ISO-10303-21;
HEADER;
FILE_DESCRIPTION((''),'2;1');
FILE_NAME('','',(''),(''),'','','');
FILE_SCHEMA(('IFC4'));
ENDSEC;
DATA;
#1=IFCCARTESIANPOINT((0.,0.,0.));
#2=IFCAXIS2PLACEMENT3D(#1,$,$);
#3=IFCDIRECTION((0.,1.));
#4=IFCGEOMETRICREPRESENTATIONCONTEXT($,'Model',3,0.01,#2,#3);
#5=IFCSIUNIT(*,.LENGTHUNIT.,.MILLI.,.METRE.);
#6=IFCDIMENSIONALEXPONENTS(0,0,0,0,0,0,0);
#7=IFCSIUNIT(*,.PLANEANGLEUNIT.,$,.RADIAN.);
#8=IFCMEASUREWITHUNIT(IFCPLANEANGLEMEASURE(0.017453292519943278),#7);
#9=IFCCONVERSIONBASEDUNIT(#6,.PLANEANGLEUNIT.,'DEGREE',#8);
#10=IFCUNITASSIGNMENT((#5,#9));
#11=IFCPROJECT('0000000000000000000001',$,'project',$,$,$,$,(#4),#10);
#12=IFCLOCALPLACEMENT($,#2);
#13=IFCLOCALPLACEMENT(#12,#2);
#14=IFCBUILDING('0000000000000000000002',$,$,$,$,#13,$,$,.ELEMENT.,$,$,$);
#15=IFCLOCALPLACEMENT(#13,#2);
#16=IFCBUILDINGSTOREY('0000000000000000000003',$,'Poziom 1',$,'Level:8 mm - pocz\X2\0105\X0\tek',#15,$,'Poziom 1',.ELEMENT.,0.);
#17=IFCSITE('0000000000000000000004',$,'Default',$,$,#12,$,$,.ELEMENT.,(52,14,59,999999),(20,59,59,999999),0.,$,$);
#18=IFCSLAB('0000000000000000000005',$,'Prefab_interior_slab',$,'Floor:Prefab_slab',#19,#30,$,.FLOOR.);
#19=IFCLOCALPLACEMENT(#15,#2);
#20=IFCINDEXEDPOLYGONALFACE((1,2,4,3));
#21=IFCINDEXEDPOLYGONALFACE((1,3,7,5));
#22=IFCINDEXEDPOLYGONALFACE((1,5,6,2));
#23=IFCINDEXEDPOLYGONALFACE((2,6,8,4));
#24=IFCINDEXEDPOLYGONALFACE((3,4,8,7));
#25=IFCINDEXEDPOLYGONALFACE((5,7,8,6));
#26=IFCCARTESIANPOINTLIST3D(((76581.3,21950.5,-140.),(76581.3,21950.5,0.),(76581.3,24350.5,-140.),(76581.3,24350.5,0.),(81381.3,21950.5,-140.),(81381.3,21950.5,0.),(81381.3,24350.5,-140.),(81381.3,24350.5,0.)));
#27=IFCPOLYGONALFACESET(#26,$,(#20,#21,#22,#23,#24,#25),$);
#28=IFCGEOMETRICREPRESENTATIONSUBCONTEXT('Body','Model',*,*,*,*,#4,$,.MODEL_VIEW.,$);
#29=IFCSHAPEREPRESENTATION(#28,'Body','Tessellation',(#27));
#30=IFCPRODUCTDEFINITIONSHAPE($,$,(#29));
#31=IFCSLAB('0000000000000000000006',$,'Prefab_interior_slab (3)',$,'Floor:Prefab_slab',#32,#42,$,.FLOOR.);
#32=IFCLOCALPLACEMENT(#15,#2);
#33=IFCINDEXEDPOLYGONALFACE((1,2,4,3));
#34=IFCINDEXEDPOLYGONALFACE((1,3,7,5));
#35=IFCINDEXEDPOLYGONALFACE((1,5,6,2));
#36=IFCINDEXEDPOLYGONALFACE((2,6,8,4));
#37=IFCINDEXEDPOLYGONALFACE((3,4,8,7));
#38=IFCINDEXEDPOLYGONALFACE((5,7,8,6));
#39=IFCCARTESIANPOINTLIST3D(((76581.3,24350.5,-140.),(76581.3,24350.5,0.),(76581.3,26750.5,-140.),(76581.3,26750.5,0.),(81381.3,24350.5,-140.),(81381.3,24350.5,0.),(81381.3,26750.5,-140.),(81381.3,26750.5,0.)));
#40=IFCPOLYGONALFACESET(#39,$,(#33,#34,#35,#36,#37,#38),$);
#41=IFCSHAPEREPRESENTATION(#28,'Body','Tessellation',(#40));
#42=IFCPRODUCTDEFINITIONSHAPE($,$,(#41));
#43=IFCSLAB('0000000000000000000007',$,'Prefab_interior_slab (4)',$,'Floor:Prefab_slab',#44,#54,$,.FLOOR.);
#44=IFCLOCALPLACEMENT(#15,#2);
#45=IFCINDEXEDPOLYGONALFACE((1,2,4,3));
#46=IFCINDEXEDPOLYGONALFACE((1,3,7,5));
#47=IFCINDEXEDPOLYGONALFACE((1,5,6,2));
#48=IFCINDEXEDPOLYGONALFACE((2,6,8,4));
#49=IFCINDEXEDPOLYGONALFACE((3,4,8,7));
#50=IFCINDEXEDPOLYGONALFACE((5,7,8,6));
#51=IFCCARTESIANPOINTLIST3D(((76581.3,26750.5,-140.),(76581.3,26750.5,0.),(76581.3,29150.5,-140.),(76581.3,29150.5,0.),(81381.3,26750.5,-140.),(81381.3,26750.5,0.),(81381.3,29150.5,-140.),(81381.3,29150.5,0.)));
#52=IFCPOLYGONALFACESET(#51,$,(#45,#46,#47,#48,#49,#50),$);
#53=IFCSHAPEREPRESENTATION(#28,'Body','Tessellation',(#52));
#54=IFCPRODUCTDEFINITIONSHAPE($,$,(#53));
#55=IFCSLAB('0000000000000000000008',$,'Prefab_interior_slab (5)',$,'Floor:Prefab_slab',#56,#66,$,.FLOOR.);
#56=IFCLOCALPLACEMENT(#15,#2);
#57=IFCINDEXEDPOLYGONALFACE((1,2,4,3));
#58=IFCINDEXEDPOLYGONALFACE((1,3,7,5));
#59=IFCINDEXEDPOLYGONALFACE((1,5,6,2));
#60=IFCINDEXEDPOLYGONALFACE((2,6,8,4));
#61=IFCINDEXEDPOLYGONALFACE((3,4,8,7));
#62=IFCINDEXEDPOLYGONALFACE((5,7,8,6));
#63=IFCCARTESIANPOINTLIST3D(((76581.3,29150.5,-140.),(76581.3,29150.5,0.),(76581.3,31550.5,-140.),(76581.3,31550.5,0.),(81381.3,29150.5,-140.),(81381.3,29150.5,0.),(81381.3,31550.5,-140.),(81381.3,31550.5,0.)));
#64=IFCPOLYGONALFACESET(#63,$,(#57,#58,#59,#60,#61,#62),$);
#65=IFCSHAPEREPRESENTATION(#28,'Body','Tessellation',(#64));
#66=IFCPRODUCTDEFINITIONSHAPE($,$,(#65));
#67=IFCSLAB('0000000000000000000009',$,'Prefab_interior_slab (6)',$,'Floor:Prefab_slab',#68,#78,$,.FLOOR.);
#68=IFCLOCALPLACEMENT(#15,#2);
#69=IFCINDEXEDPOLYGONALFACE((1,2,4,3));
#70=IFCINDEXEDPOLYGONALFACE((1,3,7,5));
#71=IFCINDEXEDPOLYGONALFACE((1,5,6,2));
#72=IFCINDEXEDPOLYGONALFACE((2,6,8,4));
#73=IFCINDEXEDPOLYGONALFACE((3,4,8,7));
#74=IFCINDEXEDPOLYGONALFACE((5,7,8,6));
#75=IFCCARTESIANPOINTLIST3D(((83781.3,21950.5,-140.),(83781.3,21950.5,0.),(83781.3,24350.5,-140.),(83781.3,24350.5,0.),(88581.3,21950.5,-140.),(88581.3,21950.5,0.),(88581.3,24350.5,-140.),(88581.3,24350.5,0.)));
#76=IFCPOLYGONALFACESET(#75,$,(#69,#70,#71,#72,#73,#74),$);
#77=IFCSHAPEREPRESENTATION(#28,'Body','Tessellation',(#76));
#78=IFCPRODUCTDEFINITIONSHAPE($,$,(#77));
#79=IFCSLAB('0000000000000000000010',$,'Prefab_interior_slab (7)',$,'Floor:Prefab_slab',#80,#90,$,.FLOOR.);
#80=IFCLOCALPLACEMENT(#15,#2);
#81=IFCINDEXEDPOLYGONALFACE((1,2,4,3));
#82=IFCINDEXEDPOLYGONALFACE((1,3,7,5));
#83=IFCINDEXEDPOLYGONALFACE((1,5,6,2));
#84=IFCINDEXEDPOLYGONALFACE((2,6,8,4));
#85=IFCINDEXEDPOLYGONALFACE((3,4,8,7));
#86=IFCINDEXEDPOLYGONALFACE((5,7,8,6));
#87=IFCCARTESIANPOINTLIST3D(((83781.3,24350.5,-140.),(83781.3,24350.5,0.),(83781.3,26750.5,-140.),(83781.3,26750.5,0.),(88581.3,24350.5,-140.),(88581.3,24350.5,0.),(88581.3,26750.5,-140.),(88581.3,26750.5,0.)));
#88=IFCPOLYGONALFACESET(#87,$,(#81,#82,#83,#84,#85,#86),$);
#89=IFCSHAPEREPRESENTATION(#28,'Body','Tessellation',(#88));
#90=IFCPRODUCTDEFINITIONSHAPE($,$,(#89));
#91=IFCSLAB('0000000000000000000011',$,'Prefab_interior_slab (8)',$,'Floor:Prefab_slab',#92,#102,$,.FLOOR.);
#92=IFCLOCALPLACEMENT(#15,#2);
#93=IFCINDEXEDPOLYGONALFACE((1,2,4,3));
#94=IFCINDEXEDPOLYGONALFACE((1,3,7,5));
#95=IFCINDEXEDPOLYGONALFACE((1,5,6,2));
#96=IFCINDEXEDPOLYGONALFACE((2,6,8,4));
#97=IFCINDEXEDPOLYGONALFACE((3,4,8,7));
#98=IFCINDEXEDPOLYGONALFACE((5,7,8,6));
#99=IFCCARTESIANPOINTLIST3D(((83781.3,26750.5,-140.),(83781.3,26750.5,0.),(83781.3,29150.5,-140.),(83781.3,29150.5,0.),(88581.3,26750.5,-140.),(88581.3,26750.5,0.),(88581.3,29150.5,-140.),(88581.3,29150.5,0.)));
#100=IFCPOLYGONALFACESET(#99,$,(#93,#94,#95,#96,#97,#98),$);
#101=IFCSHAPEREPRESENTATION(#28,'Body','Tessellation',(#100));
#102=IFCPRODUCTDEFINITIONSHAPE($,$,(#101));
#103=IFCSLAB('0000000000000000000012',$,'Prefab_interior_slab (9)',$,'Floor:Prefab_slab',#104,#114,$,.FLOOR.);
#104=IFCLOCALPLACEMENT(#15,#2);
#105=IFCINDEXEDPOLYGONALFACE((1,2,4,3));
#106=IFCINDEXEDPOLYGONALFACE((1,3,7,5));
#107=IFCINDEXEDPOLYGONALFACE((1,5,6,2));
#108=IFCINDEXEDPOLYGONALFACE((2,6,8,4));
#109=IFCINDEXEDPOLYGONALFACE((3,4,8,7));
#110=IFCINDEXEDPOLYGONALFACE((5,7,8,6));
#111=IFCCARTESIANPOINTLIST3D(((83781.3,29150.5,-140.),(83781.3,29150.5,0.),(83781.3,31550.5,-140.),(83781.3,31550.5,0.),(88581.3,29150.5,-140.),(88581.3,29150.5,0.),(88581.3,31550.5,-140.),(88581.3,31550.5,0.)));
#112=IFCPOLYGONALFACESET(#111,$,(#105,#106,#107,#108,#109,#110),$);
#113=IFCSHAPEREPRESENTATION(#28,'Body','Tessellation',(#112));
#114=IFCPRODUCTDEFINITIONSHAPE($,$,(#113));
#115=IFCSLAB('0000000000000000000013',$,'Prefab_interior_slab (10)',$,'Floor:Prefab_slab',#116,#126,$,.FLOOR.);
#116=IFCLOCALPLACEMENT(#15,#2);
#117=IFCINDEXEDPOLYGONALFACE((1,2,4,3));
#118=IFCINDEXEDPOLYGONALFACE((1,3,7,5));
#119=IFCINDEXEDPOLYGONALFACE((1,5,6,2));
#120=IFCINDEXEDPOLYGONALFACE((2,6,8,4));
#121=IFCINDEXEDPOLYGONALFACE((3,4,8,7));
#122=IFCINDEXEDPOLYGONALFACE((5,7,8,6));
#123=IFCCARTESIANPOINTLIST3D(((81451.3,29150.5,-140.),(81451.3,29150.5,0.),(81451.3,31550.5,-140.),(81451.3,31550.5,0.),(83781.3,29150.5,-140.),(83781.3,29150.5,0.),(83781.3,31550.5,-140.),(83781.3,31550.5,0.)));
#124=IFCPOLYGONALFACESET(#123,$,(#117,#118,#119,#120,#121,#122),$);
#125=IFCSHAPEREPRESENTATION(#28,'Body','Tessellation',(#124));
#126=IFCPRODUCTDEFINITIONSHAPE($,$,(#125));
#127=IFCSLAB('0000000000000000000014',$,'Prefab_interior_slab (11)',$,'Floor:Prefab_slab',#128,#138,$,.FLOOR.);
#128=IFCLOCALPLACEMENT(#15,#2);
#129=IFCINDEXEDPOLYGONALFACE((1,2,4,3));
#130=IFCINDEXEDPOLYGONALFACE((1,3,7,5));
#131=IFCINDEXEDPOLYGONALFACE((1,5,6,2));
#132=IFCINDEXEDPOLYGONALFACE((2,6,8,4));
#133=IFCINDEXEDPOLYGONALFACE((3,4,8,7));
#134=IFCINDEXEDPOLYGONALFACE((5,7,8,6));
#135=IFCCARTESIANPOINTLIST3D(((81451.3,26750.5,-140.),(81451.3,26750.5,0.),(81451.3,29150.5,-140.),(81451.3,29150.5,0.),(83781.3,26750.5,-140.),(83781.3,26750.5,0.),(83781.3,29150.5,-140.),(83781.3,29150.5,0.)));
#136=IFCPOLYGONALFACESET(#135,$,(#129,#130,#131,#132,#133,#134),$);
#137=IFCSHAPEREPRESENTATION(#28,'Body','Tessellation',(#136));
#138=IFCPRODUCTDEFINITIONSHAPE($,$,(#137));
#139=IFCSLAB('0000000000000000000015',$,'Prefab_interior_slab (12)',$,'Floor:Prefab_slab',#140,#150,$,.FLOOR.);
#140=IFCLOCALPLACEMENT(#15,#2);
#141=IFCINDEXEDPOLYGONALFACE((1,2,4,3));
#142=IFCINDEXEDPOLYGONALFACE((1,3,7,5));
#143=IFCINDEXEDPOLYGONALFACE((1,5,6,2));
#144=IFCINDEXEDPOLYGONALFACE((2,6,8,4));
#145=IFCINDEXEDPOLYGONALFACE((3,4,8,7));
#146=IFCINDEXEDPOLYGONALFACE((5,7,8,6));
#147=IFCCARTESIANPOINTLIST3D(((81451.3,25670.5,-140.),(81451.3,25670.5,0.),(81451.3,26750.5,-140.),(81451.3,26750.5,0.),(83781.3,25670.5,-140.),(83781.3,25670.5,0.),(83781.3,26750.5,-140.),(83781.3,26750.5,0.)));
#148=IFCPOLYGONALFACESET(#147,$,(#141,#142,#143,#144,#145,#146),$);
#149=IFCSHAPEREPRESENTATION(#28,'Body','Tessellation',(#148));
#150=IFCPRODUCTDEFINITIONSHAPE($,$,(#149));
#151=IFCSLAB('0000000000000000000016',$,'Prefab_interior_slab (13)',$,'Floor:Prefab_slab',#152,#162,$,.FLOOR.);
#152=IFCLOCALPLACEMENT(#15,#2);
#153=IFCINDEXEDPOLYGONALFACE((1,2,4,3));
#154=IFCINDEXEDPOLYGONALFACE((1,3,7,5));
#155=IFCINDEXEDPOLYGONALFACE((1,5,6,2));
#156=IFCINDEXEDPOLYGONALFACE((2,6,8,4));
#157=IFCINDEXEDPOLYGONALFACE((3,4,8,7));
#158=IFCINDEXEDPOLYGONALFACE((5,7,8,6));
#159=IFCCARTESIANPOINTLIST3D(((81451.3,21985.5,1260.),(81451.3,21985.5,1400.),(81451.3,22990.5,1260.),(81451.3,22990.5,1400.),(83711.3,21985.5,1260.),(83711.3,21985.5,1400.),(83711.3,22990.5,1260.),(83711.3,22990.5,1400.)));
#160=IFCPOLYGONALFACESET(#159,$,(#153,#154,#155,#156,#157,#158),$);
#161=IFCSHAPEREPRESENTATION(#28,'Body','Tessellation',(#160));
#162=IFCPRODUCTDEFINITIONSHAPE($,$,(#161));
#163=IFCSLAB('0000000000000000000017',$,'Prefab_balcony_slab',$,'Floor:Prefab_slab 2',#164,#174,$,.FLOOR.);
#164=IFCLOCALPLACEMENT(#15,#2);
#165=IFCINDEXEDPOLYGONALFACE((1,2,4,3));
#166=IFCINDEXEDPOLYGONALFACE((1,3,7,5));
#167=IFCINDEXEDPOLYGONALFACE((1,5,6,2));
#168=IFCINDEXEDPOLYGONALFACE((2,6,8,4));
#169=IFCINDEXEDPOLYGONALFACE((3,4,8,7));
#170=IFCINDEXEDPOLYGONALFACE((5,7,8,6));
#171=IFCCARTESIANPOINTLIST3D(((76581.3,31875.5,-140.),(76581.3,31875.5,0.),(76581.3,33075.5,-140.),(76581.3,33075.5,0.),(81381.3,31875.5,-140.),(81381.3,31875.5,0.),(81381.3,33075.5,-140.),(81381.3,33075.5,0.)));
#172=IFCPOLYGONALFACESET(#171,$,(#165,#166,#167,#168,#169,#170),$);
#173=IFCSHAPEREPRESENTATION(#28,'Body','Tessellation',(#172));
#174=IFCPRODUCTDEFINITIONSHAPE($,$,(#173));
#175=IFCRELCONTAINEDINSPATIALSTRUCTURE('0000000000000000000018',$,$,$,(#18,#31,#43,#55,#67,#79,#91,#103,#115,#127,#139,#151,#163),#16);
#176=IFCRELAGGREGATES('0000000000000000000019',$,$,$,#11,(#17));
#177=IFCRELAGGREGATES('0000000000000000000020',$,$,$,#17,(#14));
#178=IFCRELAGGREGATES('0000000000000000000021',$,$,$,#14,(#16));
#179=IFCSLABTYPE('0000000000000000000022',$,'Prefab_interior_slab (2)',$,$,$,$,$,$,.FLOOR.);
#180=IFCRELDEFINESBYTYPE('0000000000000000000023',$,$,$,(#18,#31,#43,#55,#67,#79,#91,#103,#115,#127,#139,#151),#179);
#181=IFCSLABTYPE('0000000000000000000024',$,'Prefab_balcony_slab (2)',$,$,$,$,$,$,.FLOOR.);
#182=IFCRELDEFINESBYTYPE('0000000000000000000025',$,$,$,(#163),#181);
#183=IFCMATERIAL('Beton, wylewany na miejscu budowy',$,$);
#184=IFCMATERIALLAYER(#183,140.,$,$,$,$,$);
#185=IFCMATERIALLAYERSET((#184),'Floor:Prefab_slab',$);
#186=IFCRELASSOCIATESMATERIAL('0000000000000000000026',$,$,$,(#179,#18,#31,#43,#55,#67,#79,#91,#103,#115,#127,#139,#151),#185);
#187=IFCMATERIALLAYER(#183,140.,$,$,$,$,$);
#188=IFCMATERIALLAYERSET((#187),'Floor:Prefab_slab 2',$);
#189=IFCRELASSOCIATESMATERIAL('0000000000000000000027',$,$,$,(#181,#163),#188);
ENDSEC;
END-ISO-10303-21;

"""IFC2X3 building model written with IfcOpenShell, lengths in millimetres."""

from ifc_helpers import new_model, entity, si_unit, converted_unit, direction, frame, frame_2d, origin, origin_2d_with_axis, place, context, subcontext, project, spatial, rectangle, extrude, material, layer, layer_set, layer_usage, type_object, element, save


model = new_model("IFC2X3")

# Units and contexts
model_context = context("Model", 3, precision=0.01, world=origin(), true_north=direction((0.0, 1.0)))
body_context = subcontext(model_context, "Body", "Model", "MODEL_VIEW")
ifc_project = project(units=[si_unit("LENGTHUNIT", "METRE", prefix="MILLI"), converted_unit("PLANEANGLEUNIT", "DEGREE", entity("IfcPlaneAngleMeasure", 0.017453292519943278), si_unit("PLANEANGLEUNIT", "RADIAN"), dimensions=[0, 0, 0, 0, 0, 0, 0])], contexts=[model_context])

# Site, building, storey
site_placement = place(None, origin())
site = spatial("IfcSite", under=ifc_project, at=site_placement, Name="Default", CompositionType="ELEMENT", RefLatitude=(52, 14, 59, 999999), RefLongitude=(20, 59, 59, 999999), RefElevation=0.0)
building_placement = place(site_placement, origin())
building = spatial("IfcBuilding", under=site, at=building_placement, CompositionType="ELEMENT")
storey_placement = place(building_placement, origin())
storey = spatial("IfcBuildingStorey", under=building, at=storey_placement, Name="Poziom 1", ObjectType="Level:8 mm - początek", LongName="Poziom 1", CompositionType="ELEMENT", Elevation=0.0)

# Slabs
ifc_material_1 = material(Name="Beton, wylewany na miejscu budowy")
ifc_layer_1 = layer(ifc_material_1, 140.0)
ifc_layer_set_1 = layer_set([ifc_layer_1], Name="Floor:Prefab_slab")
ifc_layer_usage_1 = layer_usage(ifc_layer_set_1, "AXIS3", "POSITIVE", 0.0)
slab_type_1 = type_object("IfcSlabType", Name="Prefab_interior_slab (2)", PredefinedType="FLOOR", material=ifc_layer_set_1)
slab_1_placement = place(storey_placement, origin())
element("IfcSlab", 1, at=slab_1_placement, inside=storey, type_object=slab_type_1, material=ifc_layer_usage_1, Name="Prefab_interior_slab", ObjectType="Floor:Prefab_slab", PredefinedType="FLOOR", context=body_context, shape_type="SweptSolid", body=[
    extrude(rectangle(XDim=2400.0, YDim=4800.0, at=frame_2d((0.0, 0.0), x_axis=(1.0, 0.0))), frame((78981.3, 23150.5, 0.0), z_axis=(0.0, 0.0, -1.0), x_axis=(0.0, 1.0, 0.0)), (0.0, 0.0, 1.0), 140.0),
])
ifc_layer_usage_2 = layer_usage(ifc_layer_set_1, "AXIS3", "POSITIVE", 0.0)
slab_2_placement = place(storey_placement, origin())
element("IfcSlab", 2, at=slab_2_placement, inside=storey, type_object=slab_type_1, material=ifc_layer_usage_2, Name="Prefab_interior_slab (3)", ObjectType="Floor:Prefab_slab", PredefinedType="FLOOR", context=body_context, shape_type="SweptSolid", body=[
    extrude(rectangle(XDim=2400.0, YDim=4800.0, at=frame_2d((0.0, 0.0), x_axis=(1.0, 0.0))), frame((78981.3, 25550.5, 0.0), z_axis=(0.0, 0.0, -1.0), x_axis=(0.0, 1.0, 0.0)), (0.0, 0.0, 1.0), 140.0),
])
ifc_layer_usage_3 = layer_usage(ifc_layer_set_1, "AXIS3", "POSITIVE", 0.0)
slab_3_placement = place(storey_placement, origin())
element("IfcSlab", 3, at=slab_3_placement, inside=storey, type_object=slab_type_1, material=ifc_layer_usage_3, Name="Prefab_interior_slab (4)", ObjectType="Floor:Prefab_slab", PredefinedType="FLOOR", context=body_context, shape_type="SweptSolid", body=[
    extrude(rectangle(XDim=2400.0, YDim=4800.0, at=frame_2d((0.0, 0.0), x_axis=(1.0, 0.0))), frame((78981.3, 27950.5, 0.0), z_axis=(0.0, 0.0, -1.0), x_axis=(0.0, 1.0, 0.0)), (0.0, 0.0, 1.0), 140.0),
])
ifc_layer_usage_4 = layer_usage(ifc_layer_set_1, "AXIS3", "POSITIVE", 0.0)
slab_4_placement = place(storey_placement, origin())
element("IfcSlab", 4, at=slab_4_placement, inside=storey, type_object=slab_type_1, material=ifc_layer_usage_4, Name="Prefab_interior_slab (5)", ObjectType="Floor:Prefab_slab", PredefinedType="FLOOR", context=body_context, shape_type="SweptSolid", body=[
    extrude(rectangle(XDim=2400.0, YDim=4800.0, at=frame_2d((0.0, 0.0), x_axis=(1.0, 0.0))), frame((78981.3, 30350.5, 0.0), z_axis=(0.0, 0.0, -1.0), x_axis=(0.0, 1.0, 0.0)), (0.0, 0.0, 1.0), 140.0),
])
ifc_layer_usage_5 = layer_usage(ifc_layer_set_1, "AXIS3", "POSITIVE", 0.0)
slab_5_placement = place(storey_placement, origin())
element("IfcSlab", 5, at=slab_5_placement, inside=storey, type_object=slab_type_1, material=ifc_layer_usage_5, Name="Prefab_interior_slab (6)", ObjectType="Floor:Prefab_slab", PredefinedType="FLOOR", context=body_context, shape_type="SweptSolid", body=[
    extrude(rectangle(XDim=2400.0, YDim=4800.0, at=frame_2d((0.0, 0.0), x_axis=(1.0, 0.0))), frame((86181.3, 23150.5, 0.0), z_axis=(0.0, 0.0, -1.0), x_axis=(0.0, 1.0, 0.0)), (0.0, 0.0, 1.0), 140.0),
])
ifc_layer_usage_6 = layer_usage(ifc_layer_set_1, "AXIS3", "POSITIVE", 0.0)
slab_6_placement = place(storey_placement, origin())
element("IfcSlab", 6, at=slab_6_placement, inside=storey, type_object=slab_type_1, material=ifc_layer_usage_6, Name="Prefab_interior_slab (7)", ObjectType="Floor:Prefab_slab", PredefinedType="FLOOR", context=body_context, shape_type="SweptSolid", body=[
    extrude(rectangle(XDim=2400.0, YDim=4800.0, at=frame_2d((0.0, 0.0), x_axis=(1.0, 0.0))), frame((86181.3, 25550.5, 0.0), z_axis=(0.0, 0.0, -1.0), x_axis=(0.0, 1.0, 0.0)), (0.0, 0.0, 1.0), 140.0),
])
ifc_layer_usage_7 = layer_usage(ifc_layer_set_1, "AXIS3", "POSITIVE", 0.0)
slab_7_placement = place(storey_placement, origin())
element("IfcSlab", 7, at=slab_7_placement, inside=storey, type_object=slab_type_1, material=ifc_layer_usage_7, Name="Prefab_interior_slab (8)", ObjectType="Floor:Prefab_slab", PredefinedType="FLOOR", context=body_context, shape_type="SweptSolid", body=[
    extrude(rectangle(XDim=2400.0, YDim=4800.0, at=frame_2d((0.0, 0.0), x_axis=(1.0, 0.0))), frame((86181.3, 27950.5, 0.0), z_axis=(0.0, 0.0, -1.0), x_axis=(0.0, 1.0, 0.0)), (0.0, 0.0, 1.0), 140.0),
])
ifc_layer_usage_8 = layer_usage(ifc_layer_set_1, "AXIS3", "POSITIVE", 0.0)
slab_8_placement = place(storey_placement, origin())
element("IfcSlab", 8, at=slab_8_placement, inside=storey, type_object=slab_type_1, material=ifc_layer_usage_8, Name="Prefab_interior_slab (9)", ObjectType="Floor:Prefab_slab", PredefinedType="FLOOR", context=body_context, shape_type="SweptSolid", body=[
    extrude(rectangle(XDim=2400.0, YDim=4800.0, at=frame_2d((0.0, 0.0), x_axis=(1.0, 0.0))), frame((86181.3, 30350.5, 0.0), z_axis=(0.0, 0.0, -1.0), x_axis=(0.0, 1.0, 0.0)), (0.0, 0.0, 1.0), 140.0),
])
ifc_layer_usage_9 = layer_usage(ifc_layer_set_1, "AXIS3", "POSITIVE", 0.0)
slab_9_placement = place(storey_placement, origin())
element("IfcSlab", 9, at=slab_9_placement, inside=storey, type_object=slab_type_1, material=ifc_layer_usage_9, Name="Prefab_interior_slab (10)", ObjectType="Floor:Prefab_slab", PredefinedType="FLOOR", context=body_context, shape_type="SweptSolid", body=[
    extrude(rectangle(XDim=2400.0, YDim=2330.0, at=frame_2d((0.0, 0.0), x_axis=(1.0, 0.0))), frame((82616.3, 30350.5, 0.0), z_axis=(0.0, 0.0, -1.0), x_axis=(0.0, 1.0, 0.0)), (0.0, 0.0, 1.0), 140.0),
])
ifc_layer_usage_10 = layer_usage(ifc_layer_set_1, "AXIS3", "POSITIVE", 0.0)
slab_10_placement = place(storey_placement, origin())
element("IfcSlab", 10, at=slab_10_placement, inside=storey, type_object=slab_type_1, material=ifc_layer_usage_10, Name="Prefab_interior_slab (11)", ObjectType="Floor:Prefab_slab", PredefinedType="FLOOR", context=body_context, shape_type="SweptSolid", body=[
    extrude(rectangle(XDim=2400.0, YDim=2330.0, at=frame_2d((0.0, 0.0), x_axis=(1.0, 0.0))), frame((82616.3, 27950.5, 0.0), z_axis=(0.0, 0.0, -1.0), x_axis=(0.0, 1.0, 0.0)), (0.0, 0.0, 1.0), 140.0),
])
ifc_layer_usage_11 = layer_usage(ifc_layer_set_1, "AXIS3", "POSITIVE", 0.0)
slab_11_placement = place(storey_placement, origin())
element("IfcSlab", 11, at=slab_11_placement, inside=storey, type_object=slab_type_1, material=ifc_layer_usage_11, Name="Prefab_interior_slab (12)", ObjectType="Floor:Prefab_slab", PredefinedType="FLOOR", context=body_context, shape_type="SweptSolid", body=[
    extrude(rectangle(XDim=1080.0, YDim=2330.0, at=frame_2d((0.0, 0.0), x_axis=(1.0, 0.0))), frame((82616.3, 26210.5, 0.0), z_axis=(0.0, 0.0, -1.0), x_axis=(0.0, 1.0, 0.0)), (0.0, 0.0, 1.0), 140.0),
])
ifc_layer_usage_12 = layer_usage(ifc_layer_set_1, "AXIS3", "POSITIVE", 0.0)
slab_12_placement = place(storey_placement, origin())
element("IfcSlab", 12, at=slab_12_placement, inside=storey, type_object=slab_type_1, material=ifc_layer_usage_12, Name="Prefab_interior_slab (13)", ObjectType="Floor:Prefab_slab", PredefinedType="FLOOR", context=body_context, shape_type="SweptSolid", body=[
    extrude(rectangle(XDim=1005.0, YDim=2260.0, at=origin_2d_with_axis()), frame((82581.3, 22488.0, 1400.0), z_axis=(0.0, 0.0, -1.0), x_axis=(0.0, 1.0, 0.0)), (0.0, 0.0, 1.0), 140.0),
])
ifc_layer_2 = layer(ifc_material_1, 140.0)
ifc_layer_set_2 = layer_set([ifc_layer_2], Name="Floor:Prefab_slab 2")
ifc_layer_usage_13 = layer_usage(ifc_layer_set_2, "AXIS3", "POSITIVE", 0.0)
slab_type_2 = type_object("IfcSlabType", Name="Prefab_balcony_slab (2)", PredefinedType="FLOOR", material=ifc_layer_set_2)
slab_13_placement = place(storey_placement, origin())
element("IfcSlab", 13, at=slab_13_placement, inside=storey, type_object=slab_type_2, material=ifc_layer_usage_13, Name="Prefab_balcony_slab", ObjectType="Floor:Prefab_slab 2", PredefinedType="FLOOR", context=body_context, shape_type="SweptSolid", body=[
    extrude(rectangle(XDim=1200.0, YDim=4800.0, at=frame_2d((0.0, 0.0), x_axis=(1.0, 0.0))), frame((78981.3, 32475.5, 0.0), z_axis=(0.0, 0.0, -1.0), x_axis=(0.0, 1.0, 0.0)), (0.0, 0.0, 1.0), 140.0),
])

save(model, "model.ifc")
